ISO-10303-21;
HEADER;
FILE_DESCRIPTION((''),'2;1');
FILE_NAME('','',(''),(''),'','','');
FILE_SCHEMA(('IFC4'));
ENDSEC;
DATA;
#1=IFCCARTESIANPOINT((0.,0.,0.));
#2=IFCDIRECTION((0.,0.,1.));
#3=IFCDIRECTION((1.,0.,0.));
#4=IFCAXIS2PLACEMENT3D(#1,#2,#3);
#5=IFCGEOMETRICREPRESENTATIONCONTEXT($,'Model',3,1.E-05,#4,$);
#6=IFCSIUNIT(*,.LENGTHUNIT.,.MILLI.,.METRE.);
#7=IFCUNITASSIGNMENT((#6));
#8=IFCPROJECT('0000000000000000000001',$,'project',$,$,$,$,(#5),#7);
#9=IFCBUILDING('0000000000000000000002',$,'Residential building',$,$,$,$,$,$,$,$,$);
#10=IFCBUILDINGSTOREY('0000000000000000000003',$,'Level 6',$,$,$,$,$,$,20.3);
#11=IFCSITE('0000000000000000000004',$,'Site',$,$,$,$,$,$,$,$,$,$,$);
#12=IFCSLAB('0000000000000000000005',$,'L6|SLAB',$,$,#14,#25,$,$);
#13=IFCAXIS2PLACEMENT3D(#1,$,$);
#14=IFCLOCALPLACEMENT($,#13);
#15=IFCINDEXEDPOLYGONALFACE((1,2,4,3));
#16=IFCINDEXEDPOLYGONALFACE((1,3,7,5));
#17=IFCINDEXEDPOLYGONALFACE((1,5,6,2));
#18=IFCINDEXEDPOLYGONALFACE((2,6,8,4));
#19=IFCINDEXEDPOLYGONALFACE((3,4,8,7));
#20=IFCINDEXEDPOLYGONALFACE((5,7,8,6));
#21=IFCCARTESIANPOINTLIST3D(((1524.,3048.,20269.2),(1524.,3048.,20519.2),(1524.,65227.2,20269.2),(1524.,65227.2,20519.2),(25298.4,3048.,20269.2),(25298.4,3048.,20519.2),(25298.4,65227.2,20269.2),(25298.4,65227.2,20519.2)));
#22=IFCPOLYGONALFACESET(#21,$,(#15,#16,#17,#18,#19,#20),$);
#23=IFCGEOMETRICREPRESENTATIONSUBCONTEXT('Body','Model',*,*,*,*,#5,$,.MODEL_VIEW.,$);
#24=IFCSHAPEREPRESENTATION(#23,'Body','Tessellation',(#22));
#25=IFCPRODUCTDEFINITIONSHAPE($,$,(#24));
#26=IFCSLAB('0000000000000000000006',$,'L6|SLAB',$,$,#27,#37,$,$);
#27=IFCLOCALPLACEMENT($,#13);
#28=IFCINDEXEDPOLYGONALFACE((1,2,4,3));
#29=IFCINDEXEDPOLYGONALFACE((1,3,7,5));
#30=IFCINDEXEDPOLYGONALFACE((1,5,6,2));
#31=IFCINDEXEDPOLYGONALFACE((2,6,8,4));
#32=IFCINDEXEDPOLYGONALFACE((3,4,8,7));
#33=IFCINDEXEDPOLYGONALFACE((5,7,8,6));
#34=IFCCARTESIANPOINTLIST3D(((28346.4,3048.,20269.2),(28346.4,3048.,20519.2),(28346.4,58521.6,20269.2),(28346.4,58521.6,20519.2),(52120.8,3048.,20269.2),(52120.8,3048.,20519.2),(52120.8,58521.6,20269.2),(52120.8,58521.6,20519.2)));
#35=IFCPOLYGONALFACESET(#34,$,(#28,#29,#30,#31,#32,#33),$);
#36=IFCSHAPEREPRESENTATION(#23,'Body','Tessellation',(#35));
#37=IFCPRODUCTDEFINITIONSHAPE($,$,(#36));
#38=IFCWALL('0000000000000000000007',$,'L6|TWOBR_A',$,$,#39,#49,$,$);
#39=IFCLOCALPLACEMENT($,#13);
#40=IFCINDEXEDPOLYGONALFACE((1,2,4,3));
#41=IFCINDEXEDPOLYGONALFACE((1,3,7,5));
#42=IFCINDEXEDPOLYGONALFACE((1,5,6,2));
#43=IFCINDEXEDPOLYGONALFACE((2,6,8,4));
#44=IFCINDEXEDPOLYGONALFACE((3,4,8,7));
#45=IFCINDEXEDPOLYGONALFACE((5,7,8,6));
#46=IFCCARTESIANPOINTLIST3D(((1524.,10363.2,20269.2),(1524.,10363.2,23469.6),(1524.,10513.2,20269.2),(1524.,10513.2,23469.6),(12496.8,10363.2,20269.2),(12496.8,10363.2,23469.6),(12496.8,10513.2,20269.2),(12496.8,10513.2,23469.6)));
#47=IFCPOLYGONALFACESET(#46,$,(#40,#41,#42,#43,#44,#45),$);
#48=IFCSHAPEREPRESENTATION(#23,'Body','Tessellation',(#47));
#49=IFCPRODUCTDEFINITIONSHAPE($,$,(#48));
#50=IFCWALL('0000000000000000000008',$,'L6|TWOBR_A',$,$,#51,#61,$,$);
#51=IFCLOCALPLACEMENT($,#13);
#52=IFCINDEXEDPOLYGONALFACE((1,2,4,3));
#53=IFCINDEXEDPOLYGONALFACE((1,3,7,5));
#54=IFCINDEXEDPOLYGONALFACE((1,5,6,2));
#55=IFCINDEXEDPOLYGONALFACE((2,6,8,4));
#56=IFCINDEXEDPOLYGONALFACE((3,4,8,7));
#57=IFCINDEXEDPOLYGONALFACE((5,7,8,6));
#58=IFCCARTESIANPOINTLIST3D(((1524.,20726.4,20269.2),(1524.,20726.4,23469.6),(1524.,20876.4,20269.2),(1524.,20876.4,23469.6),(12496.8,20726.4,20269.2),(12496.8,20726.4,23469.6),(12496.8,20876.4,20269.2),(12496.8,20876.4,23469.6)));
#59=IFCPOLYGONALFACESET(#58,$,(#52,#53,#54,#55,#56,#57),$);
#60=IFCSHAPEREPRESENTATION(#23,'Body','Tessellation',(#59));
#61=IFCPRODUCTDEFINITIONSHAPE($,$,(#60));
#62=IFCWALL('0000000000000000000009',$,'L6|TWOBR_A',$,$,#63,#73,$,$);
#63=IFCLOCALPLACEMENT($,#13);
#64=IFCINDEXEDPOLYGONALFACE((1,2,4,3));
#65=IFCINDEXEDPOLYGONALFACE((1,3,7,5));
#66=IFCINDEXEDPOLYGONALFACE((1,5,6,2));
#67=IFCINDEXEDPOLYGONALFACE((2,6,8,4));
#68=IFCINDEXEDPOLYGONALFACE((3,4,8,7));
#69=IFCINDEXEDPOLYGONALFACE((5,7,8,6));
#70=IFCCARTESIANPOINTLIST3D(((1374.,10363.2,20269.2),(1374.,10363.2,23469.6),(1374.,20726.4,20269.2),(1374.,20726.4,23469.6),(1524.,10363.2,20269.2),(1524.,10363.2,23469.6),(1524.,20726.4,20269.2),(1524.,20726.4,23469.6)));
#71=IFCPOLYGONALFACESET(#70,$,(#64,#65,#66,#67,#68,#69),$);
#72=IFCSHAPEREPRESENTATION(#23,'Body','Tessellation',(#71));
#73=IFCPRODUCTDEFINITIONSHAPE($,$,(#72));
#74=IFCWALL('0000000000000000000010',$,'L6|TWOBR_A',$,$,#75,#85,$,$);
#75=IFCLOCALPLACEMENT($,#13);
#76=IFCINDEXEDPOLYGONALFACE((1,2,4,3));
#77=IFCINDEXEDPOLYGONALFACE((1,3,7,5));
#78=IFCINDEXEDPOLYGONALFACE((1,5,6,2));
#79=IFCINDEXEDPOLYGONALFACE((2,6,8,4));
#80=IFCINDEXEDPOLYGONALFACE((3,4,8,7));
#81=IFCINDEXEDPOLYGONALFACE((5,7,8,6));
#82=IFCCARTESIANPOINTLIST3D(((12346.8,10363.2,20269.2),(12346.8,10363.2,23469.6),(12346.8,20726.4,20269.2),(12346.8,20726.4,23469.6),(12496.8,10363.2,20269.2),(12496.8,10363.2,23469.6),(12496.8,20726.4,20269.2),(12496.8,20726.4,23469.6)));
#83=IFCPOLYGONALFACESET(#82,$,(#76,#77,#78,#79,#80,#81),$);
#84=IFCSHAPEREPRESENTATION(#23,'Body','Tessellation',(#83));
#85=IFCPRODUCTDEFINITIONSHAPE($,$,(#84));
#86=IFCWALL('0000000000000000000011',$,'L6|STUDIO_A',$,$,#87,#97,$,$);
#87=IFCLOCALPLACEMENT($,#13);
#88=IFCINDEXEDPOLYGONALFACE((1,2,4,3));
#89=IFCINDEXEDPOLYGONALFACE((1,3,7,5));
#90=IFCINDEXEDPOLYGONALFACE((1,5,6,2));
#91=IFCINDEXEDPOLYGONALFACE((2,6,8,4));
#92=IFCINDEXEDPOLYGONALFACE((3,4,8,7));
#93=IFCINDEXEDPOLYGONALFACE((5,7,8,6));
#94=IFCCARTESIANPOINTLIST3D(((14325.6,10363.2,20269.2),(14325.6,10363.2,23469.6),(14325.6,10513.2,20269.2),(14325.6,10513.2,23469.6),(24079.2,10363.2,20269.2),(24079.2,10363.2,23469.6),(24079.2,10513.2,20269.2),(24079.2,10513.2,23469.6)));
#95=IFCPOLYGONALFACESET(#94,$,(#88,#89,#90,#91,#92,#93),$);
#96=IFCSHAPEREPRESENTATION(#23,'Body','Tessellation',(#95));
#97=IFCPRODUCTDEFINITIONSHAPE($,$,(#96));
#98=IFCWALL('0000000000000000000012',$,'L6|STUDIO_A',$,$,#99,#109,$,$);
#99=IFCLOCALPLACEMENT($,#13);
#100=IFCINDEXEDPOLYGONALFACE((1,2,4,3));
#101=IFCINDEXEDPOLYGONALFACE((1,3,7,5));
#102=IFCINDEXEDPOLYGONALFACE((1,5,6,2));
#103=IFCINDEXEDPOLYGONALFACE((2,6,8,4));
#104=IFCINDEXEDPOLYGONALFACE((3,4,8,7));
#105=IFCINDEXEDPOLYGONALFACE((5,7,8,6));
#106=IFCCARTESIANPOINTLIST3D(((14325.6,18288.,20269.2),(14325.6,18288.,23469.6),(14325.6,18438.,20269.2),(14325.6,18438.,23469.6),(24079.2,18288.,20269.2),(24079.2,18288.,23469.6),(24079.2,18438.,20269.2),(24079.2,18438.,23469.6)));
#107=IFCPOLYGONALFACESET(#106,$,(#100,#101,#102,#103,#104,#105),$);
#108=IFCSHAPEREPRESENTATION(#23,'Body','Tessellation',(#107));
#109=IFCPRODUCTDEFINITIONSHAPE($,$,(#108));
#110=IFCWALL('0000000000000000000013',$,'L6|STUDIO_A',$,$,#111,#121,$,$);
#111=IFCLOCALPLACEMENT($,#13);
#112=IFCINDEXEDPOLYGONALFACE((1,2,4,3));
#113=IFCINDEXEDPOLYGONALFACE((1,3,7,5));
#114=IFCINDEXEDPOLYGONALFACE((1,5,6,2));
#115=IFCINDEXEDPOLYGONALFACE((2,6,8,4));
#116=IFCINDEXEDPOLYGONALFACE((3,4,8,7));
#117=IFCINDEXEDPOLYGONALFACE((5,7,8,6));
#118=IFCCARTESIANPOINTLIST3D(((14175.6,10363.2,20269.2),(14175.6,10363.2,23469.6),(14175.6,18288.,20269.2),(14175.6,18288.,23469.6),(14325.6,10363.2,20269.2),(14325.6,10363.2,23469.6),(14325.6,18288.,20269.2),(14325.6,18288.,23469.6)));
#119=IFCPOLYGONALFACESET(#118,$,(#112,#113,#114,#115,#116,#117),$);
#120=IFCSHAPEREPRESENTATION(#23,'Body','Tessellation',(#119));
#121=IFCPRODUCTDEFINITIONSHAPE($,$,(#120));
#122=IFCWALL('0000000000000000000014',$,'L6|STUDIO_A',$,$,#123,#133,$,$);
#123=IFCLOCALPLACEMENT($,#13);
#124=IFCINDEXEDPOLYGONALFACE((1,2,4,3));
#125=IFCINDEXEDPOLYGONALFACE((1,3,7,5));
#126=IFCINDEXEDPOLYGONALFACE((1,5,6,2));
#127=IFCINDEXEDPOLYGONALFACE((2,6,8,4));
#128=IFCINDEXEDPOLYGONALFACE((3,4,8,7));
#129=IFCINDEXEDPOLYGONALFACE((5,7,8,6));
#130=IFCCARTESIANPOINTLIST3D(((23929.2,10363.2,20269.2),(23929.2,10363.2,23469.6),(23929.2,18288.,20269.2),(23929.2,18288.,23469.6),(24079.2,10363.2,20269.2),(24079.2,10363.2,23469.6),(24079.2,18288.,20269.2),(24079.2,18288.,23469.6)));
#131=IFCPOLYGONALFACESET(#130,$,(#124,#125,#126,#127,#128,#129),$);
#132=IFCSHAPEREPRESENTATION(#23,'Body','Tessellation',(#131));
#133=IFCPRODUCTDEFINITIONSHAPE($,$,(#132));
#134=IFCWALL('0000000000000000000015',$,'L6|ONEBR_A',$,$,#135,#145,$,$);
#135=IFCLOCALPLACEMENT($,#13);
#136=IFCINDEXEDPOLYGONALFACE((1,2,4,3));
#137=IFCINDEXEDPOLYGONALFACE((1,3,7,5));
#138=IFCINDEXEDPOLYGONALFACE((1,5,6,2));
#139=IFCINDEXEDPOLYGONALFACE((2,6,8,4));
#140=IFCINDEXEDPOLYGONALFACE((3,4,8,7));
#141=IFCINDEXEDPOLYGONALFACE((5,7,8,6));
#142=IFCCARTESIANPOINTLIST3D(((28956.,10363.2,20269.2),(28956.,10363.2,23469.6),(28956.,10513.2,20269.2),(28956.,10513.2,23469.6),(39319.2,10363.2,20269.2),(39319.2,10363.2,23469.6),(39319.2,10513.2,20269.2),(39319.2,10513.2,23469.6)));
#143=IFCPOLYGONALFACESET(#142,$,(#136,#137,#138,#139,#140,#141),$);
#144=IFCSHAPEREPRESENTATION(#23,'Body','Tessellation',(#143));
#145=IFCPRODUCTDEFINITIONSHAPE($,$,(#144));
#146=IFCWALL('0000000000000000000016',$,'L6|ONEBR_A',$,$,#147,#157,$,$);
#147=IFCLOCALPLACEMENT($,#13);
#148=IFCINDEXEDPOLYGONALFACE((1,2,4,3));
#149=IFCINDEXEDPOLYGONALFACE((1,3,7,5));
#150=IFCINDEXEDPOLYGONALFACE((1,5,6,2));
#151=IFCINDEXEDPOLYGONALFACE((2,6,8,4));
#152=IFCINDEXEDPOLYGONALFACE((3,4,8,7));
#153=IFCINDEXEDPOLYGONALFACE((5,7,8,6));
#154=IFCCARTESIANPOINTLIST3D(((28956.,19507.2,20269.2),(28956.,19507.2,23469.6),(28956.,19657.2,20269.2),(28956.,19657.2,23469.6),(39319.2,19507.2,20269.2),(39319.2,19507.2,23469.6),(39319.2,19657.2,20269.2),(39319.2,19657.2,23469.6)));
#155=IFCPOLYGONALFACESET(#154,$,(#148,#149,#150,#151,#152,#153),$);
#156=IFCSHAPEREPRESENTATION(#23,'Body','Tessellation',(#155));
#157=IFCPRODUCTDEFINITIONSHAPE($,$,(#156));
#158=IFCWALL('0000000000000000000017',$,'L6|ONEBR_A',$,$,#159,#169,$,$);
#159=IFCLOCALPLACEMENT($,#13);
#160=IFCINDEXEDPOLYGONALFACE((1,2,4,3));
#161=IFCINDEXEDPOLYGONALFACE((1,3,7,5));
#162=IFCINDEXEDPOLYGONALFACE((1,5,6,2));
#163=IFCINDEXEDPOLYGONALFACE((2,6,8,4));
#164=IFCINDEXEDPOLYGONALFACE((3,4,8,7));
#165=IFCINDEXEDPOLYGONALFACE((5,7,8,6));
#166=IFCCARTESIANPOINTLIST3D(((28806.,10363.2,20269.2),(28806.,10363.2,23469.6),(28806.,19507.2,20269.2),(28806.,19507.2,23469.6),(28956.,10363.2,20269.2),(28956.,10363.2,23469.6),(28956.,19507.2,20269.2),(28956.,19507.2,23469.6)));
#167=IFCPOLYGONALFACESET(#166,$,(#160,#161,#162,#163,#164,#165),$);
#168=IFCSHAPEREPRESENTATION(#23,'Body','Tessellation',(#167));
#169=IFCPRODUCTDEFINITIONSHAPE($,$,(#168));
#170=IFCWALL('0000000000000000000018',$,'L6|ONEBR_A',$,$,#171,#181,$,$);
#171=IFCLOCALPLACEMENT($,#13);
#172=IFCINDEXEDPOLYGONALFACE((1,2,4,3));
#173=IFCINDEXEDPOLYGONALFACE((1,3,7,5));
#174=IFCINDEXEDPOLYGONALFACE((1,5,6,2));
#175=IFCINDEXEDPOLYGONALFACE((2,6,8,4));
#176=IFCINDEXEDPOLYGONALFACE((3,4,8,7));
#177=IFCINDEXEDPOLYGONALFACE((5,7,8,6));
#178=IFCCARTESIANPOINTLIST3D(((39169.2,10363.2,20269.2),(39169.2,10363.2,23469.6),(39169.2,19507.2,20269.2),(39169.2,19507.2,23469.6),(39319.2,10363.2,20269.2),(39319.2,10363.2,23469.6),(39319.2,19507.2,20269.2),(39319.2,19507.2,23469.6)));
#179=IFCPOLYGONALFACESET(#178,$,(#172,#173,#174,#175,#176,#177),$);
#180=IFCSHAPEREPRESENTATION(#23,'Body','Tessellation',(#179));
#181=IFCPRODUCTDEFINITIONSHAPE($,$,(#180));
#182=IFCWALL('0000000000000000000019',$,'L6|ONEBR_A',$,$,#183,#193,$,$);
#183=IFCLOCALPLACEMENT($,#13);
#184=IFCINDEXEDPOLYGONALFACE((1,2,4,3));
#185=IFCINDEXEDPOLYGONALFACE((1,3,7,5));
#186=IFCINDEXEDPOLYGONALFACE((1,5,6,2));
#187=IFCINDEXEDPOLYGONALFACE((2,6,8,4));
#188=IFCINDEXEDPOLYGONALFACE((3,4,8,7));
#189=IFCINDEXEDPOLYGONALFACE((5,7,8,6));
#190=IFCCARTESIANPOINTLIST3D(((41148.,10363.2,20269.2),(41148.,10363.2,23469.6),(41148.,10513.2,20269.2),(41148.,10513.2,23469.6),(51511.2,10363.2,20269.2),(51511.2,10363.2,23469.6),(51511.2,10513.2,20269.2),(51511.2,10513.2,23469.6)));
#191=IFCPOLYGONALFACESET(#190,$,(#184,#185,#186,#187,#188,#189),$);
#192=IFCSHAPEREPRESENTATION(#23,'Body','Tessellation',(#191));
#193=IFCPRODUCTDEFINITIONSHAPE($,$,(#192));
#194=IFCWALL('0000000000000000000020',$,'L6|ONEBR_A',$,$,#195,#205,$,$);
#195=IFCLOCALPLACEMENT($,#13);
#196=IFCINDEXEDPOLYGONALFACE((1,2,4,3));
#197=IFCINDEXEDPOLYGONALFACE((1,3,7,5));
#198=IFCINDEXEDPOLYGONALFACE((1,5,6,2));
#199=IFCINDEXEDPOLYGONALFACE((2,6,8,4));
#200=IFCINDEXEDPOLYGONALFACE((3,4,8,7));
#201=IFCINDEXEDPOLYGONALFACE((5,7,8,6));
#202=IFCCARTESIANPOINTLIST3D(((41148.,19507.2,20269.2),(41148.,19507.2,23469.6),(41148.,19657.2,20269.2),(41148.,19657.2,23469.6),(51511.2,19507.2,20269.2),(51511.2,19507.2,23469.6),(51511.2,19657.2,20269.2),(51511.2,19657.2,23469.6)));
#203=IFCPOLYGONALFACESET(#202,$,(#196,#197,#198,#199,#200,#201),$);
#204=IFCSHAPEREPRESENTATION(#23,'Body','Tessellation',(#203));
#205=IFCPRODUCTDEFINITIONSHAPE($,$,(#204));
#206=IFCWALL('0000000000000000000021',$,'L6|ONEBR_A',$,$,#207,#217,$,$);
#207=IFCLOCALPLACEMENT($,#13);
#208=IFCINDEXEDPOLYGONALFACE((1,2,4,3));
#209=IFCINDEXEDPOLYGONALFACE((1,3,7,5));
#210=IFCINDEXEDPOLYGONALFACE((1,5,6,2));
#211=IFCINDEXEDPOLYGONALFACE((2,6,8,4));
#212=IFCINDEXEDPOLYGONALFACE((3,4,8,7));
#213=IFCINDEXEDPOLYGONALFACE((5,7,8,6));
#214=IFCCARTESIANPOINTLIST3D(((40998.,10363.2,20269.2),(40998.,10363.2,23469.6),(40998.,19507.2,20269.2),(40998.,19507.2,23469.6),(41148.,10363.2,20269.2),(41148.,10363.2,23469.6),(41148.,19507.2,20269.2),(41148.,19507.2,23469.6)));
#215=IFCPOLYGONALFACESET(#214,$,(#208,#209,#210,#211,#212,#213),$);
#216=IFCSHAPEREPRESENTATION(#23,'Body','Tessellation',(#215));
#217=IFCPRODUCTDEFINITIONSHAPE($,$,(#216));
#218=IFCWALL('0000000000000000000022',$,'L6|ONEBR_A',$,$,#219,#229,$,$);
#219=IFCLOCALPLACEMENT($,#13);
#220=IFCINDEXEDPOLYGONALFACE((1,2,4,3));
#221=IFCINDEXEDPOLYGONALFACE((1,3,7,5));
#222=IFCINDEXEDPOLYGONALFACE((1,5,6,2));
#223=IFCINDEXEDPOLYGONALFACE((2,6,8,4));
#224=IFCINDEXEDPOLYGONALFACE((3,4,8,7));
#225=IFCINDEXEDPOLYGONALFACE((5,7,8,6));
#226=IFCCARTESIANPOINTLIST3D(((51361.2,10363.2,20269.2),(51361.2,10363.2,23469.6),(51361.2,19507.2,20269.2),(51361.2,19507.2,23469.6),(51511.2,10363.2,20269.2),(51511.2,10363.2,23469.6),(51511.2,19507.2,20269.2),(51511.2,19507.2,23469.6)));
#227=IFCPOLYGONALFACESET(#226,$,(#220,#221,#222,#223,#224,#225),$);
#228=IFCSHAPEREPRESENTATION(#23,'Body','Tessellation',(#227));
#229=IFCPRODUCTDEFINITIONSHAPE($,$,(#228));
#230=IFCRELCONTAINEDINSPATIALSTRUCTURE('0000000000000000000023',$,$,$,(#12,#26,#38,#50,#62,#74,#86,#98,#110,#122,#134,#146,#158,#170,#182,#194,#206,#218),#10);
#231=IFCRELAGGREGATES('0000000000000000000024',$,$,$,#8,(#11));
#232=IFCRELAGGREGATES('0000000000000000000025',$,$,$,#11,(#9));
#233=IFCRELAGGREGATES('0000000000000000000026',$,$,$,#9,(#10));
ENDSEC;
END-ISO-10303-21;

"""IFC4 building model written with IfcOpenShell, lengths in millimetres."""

from ifc_helpers import new_model, si_unit, frame, origin_with_axes, place, context, subcontext, project, spatial, indexed_curve, outline, extrude, element, save


model = new_model("IFC4")

# Units and contexts
model_context = context("Model", 3, precision=1e-05, world=origin_with_axes())
body_context = subcontext(model_context, "Body", "Model", "MODEL_VIEW")
ifc_project = project(units=[si_unit("LENGTHUNIT", "METRE", prefix="MILLI")], contexts=[model_context])

# Site, building, storey
site = spatial("IfcSite", under=ifc_project, Name="Site")
building = spatial("IfcBuilding", under=site, Name="Residential building")
storey = spatial("IfcBuildingStorey", under=building, Name="Level 6", Elevation=20.3)

# Slabs
slab_1_placement = place(None, frame((1524.0, 3048.0, 20269.2), z_axis=(0.0, 0.0, 1.0), x_axis=(1.0, 0.0, 0.0)))
element("IfcSlab", 1, at=slab_1_placement, inside=storey, Name="L6|SLAB", context=body_context, shape_type="SweptSolid", body=[
    extrude(outline(indexed_curve([(0.0, 0.0), (23774.4, 0.0), (23774.4, 62179.2), (0.0, 62179.2), (0.0, 0.0)])), None, (0.0, 0.0, 1.0), 250.0),
])
slab_2_placement = place(None, frame((28346.4, 3048.0, 20269.2), z_axis=(0.0, 0.0, 1.0), x_axis=(1.0, 0.0, 0.0)))
element("IfcSlab", 2, at=slab_2_placement, inside=storey, Name="L6|SLAB", context=body_context, shape_type="SweptSolid", body=[
    extrude(outline(indexed_curve([(0.0, 0.0), (23774.4, 0.0), (23774.4, 55473.6), (0.0, 55473.6), (0.0, 0.0)])), None, (0.0, 0.0, 1.0), 250.0),
])

# Walls
for number, where, z_axis, x_axis, name in (
    (3, (1524.0, 10363.2, 20269.2), (0.0, 0.0, 1.0), (1.0, 0.0, 0.0), "L6|TWOBR_A"),
    (4, (1524.0, 20726.4, 20269.2), (0.0, 0.0, 1.0), (1.0, 0.0, 0.0), "L6|TWOBR_A"),
):
    element("IfcWall", number, at=place(None, frame(where, z_axis=z_axis, x_axis=x_axis)), inside=storey, Name=name, context=body_context, shape_type="SweptSolid", body=[
        extrude(outline(indexed_curve([(0.0, 0.0), (0.0, 150.0), (10972.8, 150.0), (10972.8, 0.0), (0.0, 0.0)], self_intersect=False)), origin_with_axes(), (0.0, 0.0, 1.0), 3200.4),
    ])
for number, where, z_axis, x_axis, name in (
    (5, (1524.0, 10363.2, 20269.2), (0.0, 0.0, 1.0), (0.0, 1.0, 0.0), "L6|TWOBR_A"),
    (6, (12496.8, 10363.2, 20269.2), (0.0, 0.0, 1.0), (0.0, 1.0, 0.0), "L6|TWOBR_A"),
):
    element("IfcWall", number, at=place(None, frame(where, z_axis=z_axis, x_axis=x_axis)), inside=storey, Name=name, context=body_context, shape_type="SweptSolid", body=[
        extrude(outline(indexed_curve([(0.0, 0.0), (0.0, 150.0), (10363.2, 150.0), (10363.2, 0.0), (0.0, 0.0)], self_intersect=False)), origin_with_axes(), (0.0, 0.0, 1.0), 3200.4),
    ])
for number, where, z_axis, x_axis, name in (
    (7, (14325.6, 10363.2, 20269.2), (0.0, 0.0, 1.0), (1.0, 0.0, 0.0), "L6|STUDIO_A"),
    (8, (14325.6, 18288.0, 20269.2), (0.0, 0.0, 1.0), (1.0, 0.0, 0.0), "L6|STUDIO_A"),
):
    element("IfcWall", number, at=place(None, frame(where, z_axis=z_axis, x_axis=x_axis)), inside=storey, Name=name, context=body_context, shape_type="SweptSolid", body=[
        extrude(outline(indexed_curve([(0.0, 0.0), (0.0, 150.0), (9753.6, 150.0), (9753.6, 0.0), (0.0, 0.0)], self_intersect=False)), origin_with_axes(), (0.0, 0.0, 1.0), 3200.4),
    ])
for number, where, z_axis, x_axis, name in (
    (9, (14325.6, 10363.2, 20269.2), (0.0, 0.0, 1.0), (0.0, 1.0, 0.0), "L6|STUDIO_A"),
    (10, (24079.2, 10363.2, 20269.2), (0.0, 0.0, 1.0), (0.0, 1.0, 0.0), "L6|STUDIO_A"),
):
    element("IfcWall", number, at=place(None, frame(where, z_axis=z_axis, x_axis=x_axis)), inside=storey, Name=name, context=body_context, shape_type="SweptSolid", body=[
        extrude(outline(indexed_curve([(0.0, 0.0), (0.0, 150.0), (7924.8, 150.0), (7924.8, 0.0), (0.0, 0.0)], self_intersect=False)), origin_with_axes(), (0.0, 0.0, 1.0), 3200.4),
    ])
for number, where, z_axis, x_axis, name in (
    (11, (28956.0, 10363.2, 20269.2), (0.0, 0.0, 1.0), (1.0, 0.0, 0.0), "L6|ONEBR_A"),
    (12, (28956.0, 19507.2, 20269.2), (0.0, 0.0, 1.0), (1.0, 0.0, 0.0), "L6|ONEBR_A"),
):
    element("IfcWall", number, at=place(None, frame(where, z_axis=z_axis, x_axis=x_axis)), inside=storey, Name=name, context=body_context, shape_type="SweptSolid", body=[
        extrude(outline(indexed_curve([(0.0, 0.0), (0.0, 150.0), (10363.2, 150.0), (10363.2, 0.0), (0.0, 0.0)], self_intersect=False)), origin_with_axes(), (0.0, 0.0, 1.0), 3200.4),
    ])
for number, where, z_axis, x_axis, name in (
    (13, (28956.0, 10363.2, 20269.2), (0.0, 0.0, 1.0), (0.0, 1.0, 0.0), "L6|ONEBR_A"),
    (14, (39319.2, 10363.2, 20269.2), (0.0, 0.0, 1.0), (0.0, 1.0, 0.0), "L6|ONEBR_A"),
):
    element("IfcWall", number, at=place(None, frame(where, z_axis=z_axis, x_axis=x_axis)), inside=storey, Name=name, context=body_context, shape_type="SweptSolid", body=[
        extrude(outline(indexed_curve([(0.0, 0.0), (0.0, 150.0), (9144.0, 150.0), (9144.0, 0.0), (0.0, 0.0)], self_intersect=False)), origin_with_axes(), (0.0, 0.0, 1.0), 3200.4),
    ])
for number, where, z_axis, x_axis, name in (
    (15, (41148.0, 10363.2, 20269.2), (0.0, 0.0, 1.0), (1.0, 0.0, 0.0), "L6|ONEBR_A"),
    (16, (41148.0, 19507.2, 20269.2), (0.0, 0.0, 1.0), (1.0, 0.0, 0.0), "L6|ONEBR_A"),
):
    element("IfcWall", number, at=place(None, frame(where, z_axis=z_axis, x_axis=x_axis)), inside=storey, Name=name, context=body_context, shape_type="SweptSolid", body=[
        extrude(outline(indexed_curve([(0.0, 0.0), (0.0, 150.0), (10363.2, 150.0), (10363.2, 0.0), (0.0, 0.0)], self_intersect=False)), origin_with_axes(), (0.0, 0.0, 1.0), 3200.4),
    ])
for number, where, z_axis, x_axis, name in (
    (17, (41148.0, 10363.2, 20269.2), (0.0, 0.0, 1.0), (0.0, 1.0, 0.0), "L6|ONEBR_A"),
    (18, (51511.2, 10363.2, 20269.2), (0.0, 0.0, 1.0), (0.0, 1.0, 0.0), "L6|ONEBR_A"),
):
    element("IfcWall", number, at=place(None, frame(where, z_axis=z_axis, x_axis=x_axis)), inside=storey, Name=name, context=body_context, shape_type="SweptSolid", body=[
        extrude(outline(indexed_curve([(0.0, 0.0), (0.0, 150.0), (9144.0, 150.0), (9144.0, 0.0), (0.0, 0.0)], self_intersect=False)), origin_with_axes(), (0.0, 0.0, 1.0), 3200.4),
    ])

save(model, "model.ifc")
